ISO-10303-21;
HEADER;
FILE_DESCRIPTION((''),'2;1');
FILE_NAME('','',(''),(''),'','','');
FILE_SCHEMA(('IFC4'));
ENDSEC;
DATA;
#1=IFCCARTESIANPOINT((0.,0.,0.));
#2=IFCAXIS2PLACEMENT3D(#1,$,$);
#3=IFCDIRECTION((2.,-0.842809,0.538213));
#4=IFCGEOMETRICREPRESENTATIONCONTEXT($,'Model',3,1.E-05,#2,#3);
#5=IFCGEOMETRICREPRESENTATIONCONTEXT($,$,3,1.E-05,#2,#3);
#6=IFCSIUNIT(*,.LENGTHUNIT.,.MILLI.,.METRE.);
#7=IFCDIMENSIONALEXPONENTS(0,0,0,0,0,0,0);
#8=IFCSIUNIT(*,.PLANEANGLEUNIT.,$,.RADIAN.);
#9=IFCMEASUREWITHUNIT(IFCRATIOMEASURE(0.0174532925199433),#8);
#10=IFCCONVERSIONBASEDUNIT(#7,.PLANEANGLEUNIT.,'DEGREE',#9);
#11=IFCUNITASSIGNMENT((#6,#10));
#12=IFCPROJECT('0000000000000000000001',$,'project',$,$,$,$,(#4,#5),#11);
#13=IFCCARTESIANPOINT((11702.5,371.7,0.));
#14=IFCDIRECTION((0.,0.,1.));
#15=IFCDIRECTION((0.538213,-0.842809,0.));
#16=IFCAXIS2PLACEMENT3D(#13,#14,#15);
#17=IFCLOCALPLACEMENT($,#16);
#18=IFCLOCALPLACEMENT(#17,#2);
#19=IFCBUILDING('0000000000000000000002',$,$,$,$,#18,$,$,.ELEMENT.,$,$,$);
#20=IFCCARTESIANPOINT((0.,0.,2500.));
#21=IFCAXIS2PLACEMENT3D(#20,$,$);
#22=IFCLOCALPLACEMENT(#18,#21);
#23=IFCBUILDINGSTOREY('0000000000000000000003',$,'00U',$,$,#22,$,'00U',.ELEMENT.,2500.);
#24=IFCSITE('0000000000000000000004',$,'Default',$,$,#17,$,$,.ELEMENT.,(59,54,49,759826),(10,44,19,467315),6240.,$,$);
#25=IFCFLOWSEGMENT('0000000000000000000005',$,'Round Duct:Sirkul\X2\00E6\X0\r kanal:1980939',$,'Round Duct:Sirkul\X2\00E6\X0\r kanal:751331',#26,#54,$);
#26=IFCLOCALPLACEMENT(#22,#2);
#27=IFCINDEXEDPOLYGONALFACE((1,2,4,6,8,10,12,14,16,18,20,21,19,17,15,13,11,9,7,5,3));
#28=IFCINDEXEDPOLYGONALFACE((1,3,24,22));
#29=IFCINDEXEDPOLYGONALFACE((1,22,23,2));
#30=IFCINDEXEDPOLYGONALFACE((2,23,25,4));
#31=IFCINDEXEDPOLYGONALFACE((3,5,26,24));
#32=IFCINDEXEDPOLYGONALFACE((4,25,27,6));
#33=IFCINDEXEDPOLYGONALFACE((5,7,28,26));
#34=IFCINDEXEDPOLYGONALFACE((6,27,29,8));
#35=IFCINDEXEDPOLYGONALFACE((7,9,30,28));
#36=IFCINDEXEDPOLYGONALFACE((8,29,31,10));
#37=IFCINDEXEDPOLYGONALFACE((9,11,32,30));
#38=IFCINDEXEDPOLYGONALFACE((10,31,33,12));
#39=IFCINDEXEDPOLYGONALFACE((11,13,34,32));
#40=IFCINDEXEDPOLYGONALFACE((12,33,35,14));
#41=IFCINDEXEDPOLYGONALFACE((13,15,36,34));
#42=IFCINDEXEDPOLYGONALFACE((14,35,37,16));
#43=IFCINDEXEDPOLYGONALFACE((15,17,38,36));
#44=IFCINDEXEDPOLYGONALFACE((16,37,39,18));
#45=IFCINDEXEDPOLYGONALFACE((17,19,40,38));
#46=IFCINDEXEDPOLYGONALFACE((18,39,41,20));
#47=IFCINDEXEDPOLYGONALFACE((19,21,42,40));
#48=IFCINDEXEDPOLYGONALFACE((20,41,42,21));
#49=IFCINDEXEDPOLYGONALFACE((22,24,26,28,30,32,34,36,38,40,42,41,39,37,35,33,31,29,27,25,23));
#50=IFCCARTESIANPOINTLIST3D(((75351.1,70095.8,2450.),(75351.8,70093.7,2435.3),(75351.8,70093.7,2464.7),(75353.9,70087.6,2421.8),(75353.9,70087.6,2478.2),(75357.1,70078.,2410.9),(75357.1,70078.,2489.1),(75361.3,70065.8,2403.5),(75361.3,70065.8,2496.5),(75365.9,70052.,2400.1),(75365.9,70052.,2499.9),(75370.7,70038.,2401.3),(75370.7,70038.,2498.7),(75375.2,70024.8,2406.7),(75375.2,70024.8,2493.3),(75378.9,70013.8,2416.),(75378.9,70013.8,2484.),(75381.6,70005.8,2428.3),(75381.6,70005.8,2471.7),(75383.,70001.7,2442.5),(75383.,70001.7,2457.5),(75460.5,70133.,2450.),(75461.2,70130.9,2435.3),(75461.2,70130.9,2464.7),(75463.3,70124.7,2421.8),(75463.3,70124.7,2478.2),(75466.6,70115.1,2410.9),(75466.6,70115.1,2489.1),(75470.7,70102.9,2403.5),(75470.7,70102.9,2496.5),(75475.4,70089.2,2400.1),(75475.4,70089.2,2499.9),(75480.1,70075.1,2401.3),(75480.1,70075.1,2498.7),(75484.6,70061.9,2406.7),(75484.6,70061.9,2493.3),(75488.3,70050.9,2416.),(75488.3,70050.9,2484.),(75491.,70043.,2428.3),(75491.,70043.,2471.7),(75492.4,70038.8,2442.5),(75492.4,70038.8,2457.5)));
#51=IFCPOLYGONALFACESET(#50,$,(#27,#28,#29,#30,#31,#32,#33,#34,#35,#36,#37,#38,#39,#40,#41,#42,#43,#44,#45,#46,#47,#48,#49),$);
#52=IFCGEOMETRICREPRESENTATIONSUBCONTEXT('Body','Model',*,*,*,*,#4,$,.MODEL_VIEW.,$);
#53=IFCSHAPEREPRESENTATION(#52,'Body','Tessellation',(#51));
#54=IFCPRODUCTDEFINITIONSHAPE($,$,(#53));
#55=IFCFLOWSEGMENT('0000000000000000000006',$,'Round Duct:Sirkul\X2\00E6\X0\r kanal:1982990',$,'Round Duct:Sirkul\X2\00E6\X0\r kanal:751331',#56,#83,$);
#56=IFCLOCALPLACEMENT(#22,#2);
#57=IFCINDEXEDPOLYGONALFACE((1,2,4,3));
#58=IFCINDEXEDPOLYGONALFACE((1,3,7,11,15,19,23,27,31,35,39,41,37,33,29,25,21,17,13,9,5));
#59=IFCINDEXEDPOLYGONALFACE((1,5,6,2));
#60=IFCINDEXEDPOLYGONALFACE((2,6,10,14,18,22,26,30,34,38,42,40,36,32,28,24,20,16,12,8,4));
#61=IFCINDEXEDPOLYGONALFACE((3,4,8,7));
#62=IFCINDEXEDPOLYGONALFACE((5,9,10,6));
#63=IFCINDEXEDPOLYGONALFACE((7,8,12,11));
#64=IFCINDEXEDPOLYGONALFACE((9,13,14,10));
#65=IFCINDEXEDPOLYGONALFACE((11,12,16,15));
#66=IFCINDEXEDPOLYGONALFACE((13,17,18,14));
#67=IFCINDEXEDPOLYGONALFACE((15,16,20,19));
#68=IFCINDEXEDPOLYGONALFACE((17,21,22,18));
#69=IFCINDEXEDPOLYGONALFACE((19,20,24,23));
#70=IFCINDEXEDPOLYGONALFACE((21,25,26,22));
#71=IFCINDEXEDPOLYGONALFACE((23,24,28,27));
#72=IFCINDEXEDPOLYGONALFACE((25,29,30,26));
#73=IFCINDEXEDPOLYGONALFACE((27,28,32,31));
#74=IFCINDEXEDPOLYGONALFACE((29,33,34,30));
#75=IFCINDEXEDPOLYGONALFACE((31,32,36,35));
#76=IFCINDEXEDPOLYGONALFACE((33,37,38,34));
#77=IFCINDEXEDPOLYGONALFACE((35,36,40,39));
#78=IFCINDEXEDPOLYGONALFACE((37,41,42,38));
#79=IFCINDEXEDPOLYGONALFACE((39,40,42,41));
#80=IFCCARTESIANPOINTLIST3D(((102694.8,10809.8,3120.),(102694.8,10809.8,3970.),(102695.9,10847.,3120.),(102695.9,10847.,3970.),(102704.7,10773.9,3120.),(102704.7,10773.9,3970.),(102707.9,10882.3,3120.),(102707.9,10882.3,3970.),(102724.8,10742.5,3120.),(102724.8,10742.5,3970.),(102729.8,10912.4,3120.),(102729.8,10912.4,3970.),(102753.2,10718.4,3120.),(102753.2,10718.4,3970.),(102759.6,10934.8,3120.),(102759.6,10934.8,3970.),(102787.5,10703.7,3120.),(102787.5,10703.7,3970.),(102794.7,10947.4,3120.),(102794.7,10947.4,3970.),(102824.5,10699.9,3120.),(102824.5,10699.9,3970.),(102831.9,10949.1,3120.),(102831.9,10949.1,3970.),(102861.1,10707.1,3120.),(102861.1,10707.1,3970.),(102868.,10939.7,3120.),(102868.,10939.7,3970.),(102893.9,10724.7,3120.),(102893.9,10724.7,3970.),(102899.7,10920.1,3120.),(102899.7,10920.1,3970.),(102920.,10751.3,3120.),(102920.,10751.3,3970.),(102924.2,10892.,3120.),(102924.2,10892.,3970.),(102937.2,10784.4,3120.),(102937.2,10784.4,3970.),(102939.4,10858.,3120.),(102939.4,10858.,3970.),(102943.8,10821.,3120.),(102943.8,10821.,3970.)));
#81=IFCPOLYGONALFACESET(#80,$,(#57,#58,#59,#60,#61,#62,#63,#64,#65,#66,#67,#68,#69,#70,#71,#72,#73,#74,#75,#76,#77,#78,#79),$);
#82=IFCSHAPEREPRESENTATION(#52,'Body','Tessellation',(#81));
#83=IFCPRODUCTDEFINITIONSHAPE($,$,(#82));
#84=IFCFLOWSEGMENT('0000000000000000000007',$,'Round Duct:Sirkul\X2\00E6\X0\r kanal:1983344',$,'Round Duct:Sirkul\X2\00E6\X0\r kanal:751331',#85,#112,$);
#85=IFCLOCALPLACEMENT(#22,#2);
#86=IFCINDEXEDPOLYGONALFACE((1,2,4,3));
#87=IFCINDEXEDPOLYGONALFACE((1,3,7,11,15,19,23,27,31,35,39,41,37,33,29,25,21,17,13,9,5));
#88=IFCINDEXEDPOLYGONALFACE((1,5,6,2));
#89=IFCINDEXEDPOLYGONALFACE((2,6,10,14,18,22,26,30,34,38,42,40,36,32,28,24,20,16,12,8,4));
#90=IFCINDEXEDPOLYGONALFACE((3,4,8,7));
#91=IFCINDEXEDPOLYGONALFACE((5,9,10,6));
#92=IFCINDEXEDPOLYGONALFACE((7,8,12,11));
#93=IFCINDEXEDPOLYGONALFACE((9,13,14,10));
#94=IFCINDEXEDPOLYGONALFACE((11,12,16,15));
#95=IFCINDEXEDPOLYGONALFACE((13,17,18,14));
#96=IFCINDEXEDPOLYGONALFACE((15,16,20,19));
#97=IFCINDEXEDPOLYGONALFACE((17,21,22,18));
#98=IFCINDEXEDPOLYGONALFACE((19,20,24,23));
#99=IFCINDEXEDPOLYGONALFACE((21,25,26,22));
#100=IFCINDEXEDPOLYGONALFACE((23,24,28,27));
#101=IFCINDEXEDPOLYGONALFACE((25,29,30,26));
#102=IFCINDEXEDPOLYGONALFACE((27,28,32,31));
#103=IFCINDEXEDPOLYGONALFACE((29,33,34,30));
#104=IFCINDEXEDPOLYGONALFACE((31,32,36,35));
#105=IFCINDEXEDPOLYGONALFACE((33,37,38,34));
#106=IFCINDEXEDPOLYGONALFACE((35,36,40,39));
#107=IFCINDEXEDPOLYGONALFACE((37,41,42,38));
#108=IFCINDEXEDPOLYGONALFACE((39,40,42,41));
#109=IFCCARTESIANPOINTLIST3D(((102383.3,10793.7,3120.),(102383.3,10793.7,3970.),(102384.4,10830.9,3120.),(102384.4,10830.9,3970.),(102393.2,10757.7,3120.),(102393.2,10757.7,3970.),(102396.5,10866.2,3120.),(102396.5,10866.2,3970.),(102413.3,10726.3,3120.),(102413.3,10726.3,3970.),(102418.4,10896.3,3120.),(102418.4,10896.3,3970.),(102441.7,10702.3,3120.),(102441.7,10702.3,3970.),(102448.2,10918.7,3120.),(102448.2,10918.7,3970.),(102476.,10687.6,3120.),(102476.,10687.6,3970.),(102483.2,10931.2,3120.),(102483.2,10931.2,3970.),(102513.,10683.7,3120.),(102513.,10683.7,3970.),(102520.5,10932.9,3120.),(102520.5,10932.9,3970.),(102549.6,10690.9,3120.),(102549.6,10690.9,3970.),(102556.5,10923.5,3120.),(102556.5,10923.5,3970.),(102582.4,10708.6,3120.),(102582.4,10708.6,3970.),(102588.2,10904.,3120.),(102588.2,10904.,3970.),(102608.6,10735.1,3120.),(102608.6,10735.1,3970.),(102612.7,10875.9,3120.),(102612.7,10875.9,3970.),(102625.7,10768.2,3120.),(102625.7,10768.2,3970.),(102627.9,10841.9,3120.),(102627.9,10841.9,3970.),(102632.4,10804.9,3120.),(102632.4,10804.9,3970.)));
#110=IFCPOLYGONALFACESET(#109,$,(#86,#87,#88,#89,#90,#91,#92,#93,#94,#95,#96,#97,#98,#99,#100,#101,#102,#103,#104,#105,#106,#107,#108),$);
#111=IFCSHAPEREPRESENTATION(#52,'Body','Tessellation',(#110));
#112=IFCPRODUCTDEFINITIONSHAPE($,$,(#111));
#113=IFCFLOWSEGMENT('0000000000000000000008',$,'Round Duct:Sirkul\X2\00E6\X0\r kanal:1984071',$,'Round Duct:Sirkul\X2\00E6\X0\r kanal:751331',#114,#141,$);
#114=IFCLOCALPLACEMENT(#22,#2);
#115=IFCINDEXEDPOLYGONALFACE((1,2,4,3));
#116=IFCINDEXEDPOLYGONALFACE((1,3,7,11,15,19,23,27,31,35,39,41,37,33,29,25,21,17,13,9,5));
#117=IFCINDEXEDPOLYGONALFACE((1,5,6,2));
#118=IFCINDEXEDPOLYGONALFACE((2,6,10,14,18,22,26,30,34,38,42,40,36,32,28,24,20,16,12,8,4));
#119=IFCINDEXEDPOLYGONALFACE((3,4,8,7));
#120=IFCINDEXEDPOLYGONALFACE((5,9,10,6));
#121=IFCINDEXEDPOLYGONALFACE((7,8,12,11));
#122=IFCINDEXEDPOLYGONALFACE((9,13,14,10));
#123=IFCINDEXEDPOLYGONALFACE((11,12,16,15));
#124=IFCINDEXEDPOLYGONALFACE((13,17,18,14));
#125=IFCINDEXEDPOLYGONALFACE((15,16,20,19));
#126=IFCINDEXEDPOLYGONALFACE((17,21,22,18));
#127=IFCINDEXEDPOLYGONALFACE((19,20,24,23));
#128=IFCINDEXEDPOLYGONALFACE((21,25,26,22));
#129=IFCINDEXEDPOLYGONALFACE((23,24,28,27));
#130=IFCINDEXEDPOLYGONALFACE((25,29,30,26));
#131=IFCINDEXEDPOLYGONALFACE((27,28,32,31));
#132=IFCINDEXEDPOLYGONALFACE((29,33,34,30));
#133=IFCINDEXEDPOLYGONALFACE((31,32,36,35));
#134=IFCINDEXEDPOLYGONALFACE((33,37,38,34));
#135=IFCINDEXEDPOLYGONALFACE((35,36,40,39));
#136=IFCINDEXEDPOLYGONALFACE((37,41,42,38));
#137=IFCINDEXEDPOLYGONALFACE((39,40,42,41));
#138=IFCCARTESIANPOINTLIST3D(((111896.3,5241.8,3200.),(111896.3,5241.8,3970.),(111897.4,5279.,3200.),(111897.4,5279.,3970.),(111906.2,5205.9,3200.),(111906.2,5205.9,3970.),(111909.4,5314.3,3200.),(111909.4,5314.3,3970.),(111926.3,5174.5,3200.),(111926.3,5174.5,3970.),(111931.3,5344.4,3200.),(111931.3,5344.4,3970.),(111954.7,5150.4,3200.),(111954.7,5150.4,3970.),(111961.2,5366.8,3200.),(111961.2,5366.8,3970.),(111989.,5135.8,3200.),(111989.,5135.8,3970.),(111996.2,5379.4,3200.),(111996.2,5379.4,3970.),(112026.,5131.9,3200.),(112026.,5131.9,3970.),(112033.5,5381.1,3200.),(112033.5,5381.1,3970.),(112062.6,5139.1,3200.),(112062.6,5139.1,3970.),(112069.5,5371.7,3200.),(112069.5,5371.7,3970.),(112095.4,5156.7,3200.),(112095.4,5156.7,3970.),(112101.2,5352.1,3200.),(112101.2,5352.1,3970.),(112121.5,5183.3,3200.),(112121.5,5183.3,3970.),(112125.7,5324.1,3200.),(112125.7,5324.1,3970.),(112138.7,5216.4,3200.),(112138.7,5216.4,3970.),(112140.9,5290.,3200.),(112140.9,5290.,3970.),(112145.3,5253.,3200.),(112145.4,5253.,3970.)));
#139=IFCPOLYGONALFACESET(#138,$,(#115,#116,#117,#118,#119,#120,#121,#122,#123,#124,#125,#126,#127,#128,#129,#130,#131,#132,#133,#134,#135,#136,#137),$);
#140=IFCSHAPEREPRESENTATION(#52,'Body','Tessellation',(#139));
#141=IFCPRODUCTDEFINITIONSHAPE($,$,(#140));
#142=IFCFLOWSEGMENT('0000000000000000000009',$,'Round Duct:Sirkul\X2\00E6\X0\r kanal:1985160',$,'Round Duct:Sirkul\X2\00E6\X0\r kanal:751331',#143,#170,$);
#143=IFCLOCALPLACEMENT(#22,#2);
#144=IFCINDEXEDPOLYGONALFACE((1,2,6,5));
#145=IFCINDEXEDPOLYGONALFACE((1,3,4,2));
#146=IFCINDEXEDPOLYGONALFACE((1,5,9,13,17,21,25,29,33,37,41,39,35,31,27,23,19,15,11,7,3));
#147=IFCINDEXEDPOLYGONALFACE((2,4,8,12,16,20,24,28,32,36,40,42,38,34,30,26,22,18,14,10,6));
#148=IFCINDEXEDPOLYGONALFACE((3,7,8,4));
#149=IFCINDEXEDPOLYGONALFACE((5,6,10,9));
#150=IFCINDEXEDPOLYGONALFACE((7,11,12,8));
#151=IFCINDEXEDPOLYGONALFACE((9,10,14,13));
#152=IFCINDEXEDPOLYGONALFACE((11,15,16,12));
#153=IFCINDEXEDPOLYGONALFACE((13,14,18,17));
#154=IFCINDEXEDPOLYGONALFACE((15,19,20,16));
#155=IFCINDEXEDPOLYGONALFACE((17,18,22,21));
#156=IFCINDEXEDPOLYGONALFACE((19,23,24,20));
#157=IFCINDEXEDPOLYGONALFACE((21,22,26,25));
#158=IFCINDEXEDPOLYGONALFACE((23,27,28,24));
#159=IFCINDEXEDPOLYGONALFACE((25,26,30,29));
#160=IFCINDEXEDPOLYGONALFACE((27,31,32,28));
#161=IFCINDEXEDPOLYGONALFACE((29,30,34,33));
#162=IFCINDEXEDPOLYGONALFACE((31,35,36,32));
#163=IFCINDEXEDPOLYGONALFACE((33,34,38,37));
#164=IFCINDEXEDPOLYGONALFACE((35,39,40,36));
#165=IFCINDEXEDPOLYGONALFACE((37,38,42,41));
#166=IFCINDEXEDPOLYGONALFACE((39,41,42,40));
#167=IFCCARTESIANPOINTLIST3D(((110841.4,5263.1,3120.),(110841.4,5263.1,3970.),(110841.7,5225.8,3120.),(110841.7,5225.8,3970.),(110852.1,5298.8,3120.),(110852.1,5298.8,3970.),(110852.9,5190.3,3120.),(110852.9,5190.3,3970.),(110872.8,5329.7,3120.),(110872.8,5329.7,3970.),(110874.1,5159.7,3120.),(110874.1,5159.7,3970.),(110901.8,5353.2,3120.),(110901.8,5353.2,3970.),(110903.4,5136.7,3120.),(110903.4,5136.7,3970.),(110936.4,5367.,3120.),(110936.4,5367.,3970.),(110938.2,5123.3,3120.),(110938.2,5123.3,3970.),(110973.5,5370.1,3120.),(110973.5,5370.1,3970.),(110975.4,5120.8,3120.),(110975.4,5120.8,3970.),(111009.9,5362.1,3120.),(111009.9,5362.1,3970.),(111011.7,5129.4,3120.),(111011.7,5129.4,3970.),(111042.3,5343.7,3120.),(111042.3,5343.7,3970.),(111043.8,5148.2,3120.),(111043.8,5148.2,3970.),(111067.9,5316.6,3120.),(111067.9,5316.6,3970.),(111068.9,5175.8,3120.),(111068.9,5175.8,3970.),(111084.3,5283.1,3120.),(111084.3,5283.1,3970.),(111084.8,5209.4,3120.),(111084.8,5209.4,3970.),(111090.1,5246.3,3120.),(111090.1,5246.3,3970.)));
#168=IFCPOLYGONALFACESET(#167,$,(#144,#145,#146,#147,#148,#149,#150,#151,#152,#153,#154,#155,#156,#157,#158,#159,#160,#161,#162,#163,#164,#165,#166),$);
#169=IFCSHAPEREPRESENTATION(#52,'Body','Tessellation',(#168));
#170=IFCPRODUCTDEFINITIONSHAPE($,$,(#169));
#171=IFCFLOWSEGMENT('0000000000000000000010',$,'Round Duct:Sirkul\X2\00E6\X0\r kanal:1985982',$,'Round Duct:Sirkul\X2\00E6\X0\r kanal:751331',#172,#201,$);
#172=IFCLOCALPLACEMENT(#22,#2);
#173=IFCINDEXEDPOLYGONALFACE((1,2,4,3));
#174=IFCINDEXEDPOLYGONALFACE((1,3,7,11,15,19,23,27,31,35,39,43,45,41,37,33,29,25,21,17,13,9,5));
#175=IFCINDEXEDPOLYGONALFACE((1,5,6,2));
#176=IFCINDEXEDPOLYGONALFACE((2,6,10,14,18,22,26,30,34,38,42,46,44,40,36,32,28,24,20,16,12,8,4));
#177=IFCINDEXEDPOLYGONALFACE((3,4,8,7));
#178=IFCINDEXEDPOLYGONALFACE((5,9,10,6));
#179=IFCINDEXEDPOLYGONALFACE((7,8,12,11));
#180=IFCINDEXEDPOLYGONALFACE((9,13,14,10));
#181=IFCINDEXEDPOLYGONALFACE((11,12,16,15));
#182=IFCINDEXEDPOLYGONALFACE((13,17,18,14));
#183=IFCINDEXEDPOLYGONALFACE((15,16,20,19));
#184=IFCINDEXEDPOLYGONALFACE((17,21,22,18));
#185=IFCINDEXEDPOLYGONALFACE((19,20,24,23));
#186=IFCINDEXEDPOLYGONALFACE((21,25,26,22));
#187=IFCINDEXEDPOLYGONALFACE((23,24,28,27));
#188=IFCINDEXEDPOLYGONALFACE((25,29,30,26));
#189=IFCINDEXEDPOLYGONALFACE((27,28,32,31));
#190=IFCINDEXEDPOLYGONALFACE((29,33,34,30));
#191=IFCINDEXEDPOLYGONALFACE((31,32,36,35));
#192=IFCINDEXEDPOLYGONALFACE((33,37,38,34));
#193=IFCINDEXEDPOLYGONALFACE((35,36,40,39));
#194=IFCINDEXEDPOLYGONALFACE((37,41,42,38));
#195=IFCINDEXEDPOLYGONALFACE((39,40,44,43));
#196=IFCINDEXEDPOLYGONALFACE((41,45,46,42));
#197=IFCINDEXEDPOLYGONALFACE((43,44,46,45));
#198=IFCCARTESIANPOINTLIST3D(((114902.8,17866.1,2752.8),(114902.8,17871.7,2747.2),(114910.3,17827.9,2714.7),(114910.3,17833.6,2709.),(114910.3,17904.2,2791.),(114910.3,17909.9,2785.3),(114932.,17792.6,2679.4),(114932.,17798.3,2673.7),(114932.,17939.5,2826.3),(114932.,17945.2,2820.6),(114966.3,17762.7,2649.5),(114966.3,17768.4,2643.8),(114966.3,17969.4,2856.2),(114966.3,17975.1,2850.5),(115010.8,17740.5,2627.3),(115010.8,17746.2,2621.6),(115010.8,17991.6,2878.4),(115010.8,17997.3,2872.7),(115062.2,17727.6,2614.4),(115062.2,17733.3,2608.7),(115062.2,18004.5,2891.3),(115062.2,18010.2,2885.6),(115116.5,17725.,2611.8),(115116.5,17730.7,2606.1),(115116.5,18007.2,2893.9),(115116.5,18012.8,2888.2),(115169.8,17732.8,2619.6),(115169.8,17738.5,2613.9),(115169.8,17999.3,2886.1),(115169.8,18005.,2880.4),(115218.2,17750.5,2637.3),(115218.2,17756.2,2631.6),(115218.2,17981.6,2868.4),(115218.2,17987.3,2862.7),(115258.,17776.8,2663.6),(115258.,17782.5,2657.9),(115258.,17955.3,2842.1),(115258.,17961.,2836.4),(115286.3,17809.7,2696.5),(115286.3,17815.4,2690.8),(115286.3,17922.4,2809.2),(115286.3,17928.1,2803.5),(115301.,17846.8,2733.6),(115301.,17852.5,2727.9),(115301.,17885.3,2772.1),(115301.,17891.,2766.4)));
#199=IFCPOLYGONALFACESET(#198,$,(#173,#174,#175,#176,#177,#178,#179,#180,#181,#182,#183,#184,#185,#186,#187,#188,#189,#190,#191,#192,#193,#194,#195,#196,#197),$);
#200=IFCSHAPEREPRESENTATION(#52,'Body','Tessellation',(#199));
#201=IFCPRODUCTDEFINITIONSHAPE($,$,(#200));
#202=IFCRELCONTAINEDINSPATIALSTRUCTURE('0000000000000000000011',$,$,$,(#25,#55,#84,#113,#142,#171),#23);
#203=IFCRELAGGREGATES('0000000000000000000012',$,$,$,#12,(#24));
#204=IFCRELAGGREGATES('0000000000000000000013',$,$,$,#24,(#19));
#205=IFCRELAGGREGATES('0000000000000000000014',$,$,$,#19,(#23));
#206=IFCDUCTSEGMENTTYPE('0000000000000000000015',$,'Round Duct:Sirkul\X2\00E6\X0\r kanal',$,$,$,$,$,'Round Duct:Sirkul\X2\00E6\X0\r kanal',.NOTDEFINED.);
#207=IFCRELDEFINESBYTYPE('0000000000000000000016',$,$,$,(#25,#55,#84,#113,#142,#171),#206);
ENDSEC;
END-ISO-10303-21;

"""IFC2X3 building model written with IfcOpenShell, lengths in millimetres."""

from ifc_helpers import new_model, entity, si_unit, converted_unit, direction, frame, frame_2d, origin, origin_2d_with_axis, place, context, subcontext, project, spatial, circle, extrude, type_object, element, save


model = new_model("IFC2X3")

# Units and contexts
model_context = context("Model", 3, precision=1e-05, world=origin(), true_north=direction((2.0, -0.842809, 0.538213)))
context_of_model = context(None, 3, precision=1e-05, world=origin(), true_north=direction((2.0, -0.842809, 0.538213)))
body_context = subcontext(model_context, "Body", "Model", "MODEL_VIEW")
ifc_project = project(units=[si_unit("LENGTHUNIT", "METRE", prefix="MILLI"), converted_unit("PLANEANGLEUNIT", "DEGREE", entity("IfcRatioMeasure", 0.0174532925199433), si_unit("PLANEANGLEUNIT", "RADIAN"), dimensions=[0, 0, 0, 0, 0, 0, 0])], contexts=[model_context, context_of_model])

# Site, building, storey
site_placement = place(None, frame((11702.5, 371.7, 0.0), z_axis=(0.0, 0.0, 1.0), x_axis=(0.538213, -0.842809, 0.0)))
site = spatial("IfcSite", under=ifc_project, at=site_placement, Name="Default", CompositionType="ELEMENT", RefLatitude=(59, 54, 49, 759826), RefLongitude=(10, 44, 19, 467315), RefElevation=6240.0)
building_placement = place(site_placement, origin())
building = spatial("IfcBuilding", under=site, at=building_placement, CompositionType="ELEMENT")
storey_placement = place(building_placement, frame((0.0, 0.0, 2500.0)))
storey = spatial("IfcBuildingStorey", under=building, at=storey_placement, Name="00U", LongName="00U", CompositionType="ELEMENT", Elevation=2500.0)

# Flow segments
duct_segment_type_1 = type_object("IfcDuctSegmentType", Name="Round Duct:Sirkulær kanal", ElementType="Round Duct:Sirkulær kanal", PredefinedType="NOTDEFINED")
flow_segment_1_placement = place(storey_placement, origin())
element("IfcFlowSegment", 1, at=flow_segment_1_placement, inside=storey, type_object=duct_segment_type_1, Name="Round Duct:Sirkulær kanal:1980939", ObjectType="Round Duct:Sirkulær kanal:751331", context=body_context, shape_type="SweptSolid", body=[
    extrude(circle(Radius=50.0, at=origin_2d_with_axis()), frame((75367.1, 70048.5, 2450.0), z_axis=(0.946994, 0.321251, 0.0), x_axis=(-0.321251, 0.946994, 0.0)), (0.0, 0.0, 1.0), 115.6),
])
flow_segment_2_placement = place(storey_placement, origin())
element("IfcFlowSegment", 2, at=flow_segment_2_placement, inside=storey, type_object=duct_segment_type_1, Name="Round Duct:Sirkulær kanal:1982990", ObjectType="Round Duct:Sirkulær kanal:751331", context=body_context, shape_type="SweptSolid", body=[
    extrude(circle(Radius=125.0, at=frame_2d((0.0, 0.0), x_axis=(1.0, 0.0))), frame((102818.9, 10824.7, 3120.0), z_axis=(0.000002, 0.000001, 1.0), x_axis=(0.96392, 0.266194, -0.000002)), (0.0, 0.0, 1.0), 850.0),
])
flow_segment_3_placement = place(storey_placement, origin())
element("IfcFlowSegment", 3, at=flow_segment_3_placement, inside=storey, type_object=duct_segment_type_1, Name="Round Duct:Sirkulær kanal:1983344", ObjectType="Round Duct:Sirkulær kanal:751331", context=body_context, shape_type="SweptSolid", body=[
    extrude(circle(Radius=125.0, at=origin_2d_with_axis()), frame((102507.4, 10808.6, 3120.0), z_axis=(0.000001, 0.0, 1.0), x_axis=(0.96392, 0.266194, -0.000001)), (0.0, 0.0, 1.0), 850.0),
])
flow_segment_4_placement = place(storey_placement, origin())
element("IfcFlowSegment", 4, at=flow_segment_4_placement, inside=storey, type_object=duct_segment_type_1, Name="Round Duct:Sirkulær kanal:1984071", ObjectType="Round Duct:Sirkulær kanal:751331", context=body_context, shape_type="SweptSolid", body=[
    extrude(circle(Radius=125.0, at=frame_2d((0.0, 0.0), x_axis=(1.0, 0.0))), frame((112020.4, 5256.7, 3200.0), z_axis=(0.000001, 0.0, 1.0), x_axis=(0.96392, 0.266194, -0.000001)), (0.0, 0.0, 1.0), 770.0),
])
flow_segment_5_placement = place(storey_placement, origin())
element("IfcFlowSegment", 5, at=flow_segment_5_placement, inside=storey, type_object=duct_segment_type_1, Name="Round Duct:Sirkulær kanal:1985160", ObjectType="Round Duct:Sirkulær kanal:751331", context=body_context, shape_type="SweptSolid", body=[
    extrude(circle(Radius=125.0, at=frame_2d((0.0, 0.0), x_axis=(1.0, 0.0))), frame((110965.1, 5245.4, 3120.0), z_axis=(0.000001, 0.0, 1.0), x_axis=(0.999971, 0.007643, -0.000001)), (0.0, 0.0, 1.0), 850.0),
])
flow_segment_6_placement = place(storey_placement, origin())
element("IfcFlowSegment", 6, at=flow_segment_6_placement, inside=storey, type_object=duct_segment_type_1, Name="Round Duct:Sirkulær kanal:1985982", ObjectType="Round Duct:Sirkulær kanal:751331", context=body_context, shape_type="SweptSolid", body=[
    extrude(circle(Radius=200.0, at=frame_2d((0.0, 0.0), x_axis=(1.0, 0.0))), frame((115102.8, 17871.7, 2747.2), z_axis=(0.0, -0.707107, 0.707107), x_axis=(-1.0, 0.0, 0.0)), (0.0, 0.0, 1.0), 8.0),
])

save(model, "model.ifc")
